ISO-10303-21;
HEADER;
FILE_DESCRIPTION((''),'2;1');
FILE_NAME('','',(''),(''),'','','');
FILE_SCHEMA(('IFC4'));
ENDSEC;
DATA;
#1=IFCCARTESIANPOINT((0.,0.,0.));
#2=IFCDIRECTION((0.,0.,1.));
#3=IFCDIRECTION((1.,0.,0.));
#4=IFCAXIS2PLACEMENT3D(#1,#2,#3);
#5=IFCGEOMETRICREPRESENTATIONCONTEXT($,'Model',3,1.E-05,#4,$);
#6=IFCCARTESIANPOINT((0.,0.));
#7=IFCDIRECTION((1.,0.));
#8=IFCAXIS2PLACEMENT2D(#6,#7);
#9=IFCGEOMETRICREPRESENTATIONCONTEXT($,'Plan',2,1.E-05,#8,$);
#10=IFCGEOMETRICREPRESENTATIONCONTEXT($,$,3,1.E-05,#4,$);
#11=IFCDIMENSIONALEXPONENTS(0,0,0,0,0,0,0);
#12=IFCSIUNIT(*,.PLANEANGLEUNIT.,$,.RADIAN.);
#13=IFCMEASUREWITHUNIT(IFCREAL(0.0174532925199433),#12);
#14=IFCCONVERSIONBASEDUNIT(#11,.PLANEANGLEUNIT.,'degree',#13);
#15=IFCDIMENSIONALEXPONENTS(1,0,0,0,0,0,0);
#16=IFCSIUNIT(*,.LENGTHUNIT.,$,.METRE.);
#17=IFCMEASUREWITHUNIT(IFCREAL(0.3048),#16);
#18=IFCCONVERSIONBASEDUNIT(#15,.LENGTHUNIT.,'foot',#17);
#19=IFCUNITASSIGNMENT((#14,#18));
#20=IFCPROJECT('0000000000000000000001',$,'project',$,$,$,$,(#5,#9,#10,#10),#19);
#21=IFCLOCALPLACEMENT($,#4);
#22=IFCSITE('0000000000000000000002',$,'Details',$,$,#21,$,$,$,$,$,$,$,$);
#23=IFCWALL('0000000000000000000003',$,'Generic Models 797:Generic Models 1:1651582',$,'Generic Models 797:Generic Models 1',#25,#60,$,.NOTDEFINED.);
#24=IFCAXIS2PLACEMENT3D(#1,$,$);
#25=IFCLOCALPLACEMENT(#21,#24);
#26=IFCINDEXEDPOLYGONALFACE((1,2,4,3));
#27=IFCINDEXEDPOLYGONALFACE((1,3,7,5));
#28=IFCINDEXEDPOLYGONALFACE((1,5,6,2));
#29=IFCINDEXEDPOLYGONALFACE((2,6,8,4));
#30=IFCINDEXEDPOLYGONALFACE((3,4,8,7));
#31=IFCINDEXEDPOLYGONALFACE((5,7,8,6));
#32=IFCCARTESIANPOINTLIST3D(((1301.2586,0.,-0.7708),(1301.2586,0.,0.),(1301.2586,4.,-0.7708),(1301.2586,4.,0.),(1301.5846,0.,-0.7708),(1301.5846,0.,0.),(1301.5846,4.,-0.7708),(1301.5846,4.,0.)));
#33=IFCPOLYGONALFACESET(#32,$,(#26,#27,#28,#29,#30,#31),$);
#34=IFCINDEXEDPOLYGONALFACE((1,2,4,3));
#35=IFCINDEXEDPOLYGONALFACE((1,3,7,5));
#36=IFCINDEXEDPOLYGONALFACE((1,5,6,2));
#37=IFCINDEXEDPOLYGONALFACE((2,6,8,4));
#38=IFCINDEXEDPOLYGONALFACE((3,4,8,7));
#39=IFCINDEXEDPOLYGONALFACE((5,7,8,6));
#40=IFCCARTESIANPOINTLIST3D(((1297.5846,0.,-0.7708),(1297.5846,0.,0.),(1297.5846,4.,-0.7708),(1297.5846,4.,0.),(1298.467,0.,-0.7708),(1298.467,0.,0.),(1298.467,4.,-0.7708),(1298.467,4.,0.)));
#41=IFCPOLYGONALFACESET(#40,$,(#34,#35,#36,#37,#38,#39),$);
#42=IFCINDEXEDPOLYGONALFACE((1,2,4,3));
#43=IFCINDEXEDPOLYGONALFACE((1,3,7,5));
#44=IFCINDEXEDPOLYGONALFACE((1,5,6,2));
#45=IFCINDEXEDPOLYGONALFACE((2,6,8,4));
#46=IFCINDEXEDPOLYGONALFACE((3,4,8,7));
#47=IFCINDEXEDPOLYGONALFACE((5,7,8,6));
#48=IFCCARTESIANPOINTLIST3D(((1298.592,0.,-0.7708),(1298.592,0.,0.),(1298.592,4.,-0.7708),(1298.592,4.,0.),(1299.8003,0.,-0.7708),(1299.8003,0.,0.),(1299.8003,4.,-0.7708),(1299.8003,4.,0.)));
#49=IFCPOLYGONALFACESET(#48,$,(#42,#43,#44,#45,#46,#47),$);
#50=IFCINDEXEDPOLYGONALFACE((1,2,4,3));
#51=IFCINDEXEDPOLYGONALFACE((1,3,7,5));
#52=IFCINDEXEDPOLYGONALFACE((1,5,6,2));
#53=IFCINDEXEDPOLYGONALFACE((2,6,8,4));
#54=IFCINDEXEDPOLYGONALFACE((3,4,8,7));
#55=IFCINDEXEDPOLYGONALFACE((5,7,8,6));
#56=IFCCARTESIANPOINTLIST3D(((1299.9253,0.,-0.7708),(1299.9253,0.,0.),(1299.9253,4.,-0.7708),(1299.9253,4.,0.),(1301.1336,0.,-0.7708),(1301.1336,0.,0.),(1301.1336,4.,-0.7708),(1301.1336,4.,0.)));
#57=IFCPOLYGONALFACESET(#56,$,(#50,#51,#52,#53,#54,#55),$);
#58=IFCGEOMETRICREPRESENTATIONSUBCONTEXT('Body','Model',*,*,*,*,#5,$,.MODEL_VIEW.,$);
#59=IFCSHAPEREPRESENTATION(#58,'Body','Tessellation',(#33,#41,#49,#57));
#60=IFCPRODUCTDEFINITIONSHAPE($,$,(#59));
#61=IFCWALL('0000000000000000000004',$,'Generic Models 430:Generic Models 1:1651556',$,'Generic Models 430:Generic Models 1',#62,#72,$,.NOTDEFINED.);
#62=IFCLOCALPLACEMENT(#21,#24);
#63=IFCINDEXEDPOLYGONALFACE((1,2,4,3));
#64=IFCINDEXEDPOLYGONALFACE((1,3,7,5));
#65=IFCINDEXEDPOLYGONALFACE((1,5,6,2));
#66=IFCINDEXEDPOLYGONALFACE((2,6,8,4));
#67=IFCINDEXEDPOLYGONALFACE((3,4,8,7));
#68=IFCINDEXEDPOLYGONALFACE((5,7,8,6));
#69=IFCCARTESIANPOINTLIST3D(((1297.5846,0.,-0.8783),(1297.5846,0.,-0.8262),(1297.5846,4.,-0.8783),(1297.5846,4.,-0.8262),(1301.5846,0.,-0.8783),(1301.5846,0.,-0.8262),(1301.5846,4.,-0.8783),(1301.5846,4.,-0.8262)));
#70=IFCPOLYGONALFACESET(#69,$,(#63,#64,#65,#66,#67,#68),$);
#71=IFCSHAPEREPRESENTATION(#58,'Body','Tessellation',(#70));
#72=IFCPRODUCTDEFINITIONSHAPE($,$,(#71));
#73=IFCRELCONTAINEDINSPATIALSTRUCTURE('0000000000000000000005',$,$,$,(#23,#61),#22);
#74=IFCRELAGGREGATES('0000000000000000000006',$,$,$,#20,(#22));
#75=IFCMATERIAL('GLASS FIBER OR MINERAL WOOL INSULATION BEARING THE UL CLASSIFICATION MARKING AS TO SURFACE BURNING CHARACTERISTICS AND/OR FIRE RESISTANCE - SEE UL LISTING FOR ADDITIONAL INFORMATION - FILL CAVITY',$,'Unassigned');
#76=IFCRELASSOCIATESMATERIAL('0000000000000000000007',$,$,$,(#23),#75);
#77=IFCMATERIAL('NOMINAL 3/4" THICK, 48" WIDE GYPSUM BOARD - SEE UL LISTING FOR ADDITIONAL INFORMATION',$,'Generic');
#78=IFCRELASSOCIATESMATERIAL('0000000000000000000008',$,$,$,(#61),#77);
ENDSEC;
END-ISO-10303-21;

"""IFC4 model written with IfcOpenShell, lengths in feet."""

from ifc_helpers import new_model, entity, si_unit, converted_unit, frame, frame_2d, origin_with_axes, origin_2d_with_axis, place, context, subcontext, project, spatial, rectangle, extrude, material, element, save


model = new_model("IFC4")

# Units and contexts
model_context = context("Model", 3, precision=1e-05, world=origin_with_axes())
plan_context = context("Plan", 2, precision=1e-05, world=origin_2d_with_axis())
context_of_model = context(None, 3, precision=1e-05, world=origin_with_axes())
body_context = subcontext(model_context, "Body", "Model", "MODEL_VIEW")
ifc_project = project(units=[converted_unit("PLANEANGLEUNIT", "degree", entity("IfcReal", 0.0174532925199433), si_unit("PLANEANGLEUNIT", "RADIAN"), dimensions=[0, 0, 0, 0, 0, 0, 0]), converted_unit("LENGTHUNIT", "foot", entity("IfcReal", 0.3048), si_unit("LENGTHUNIT", "METRE"), dimensions=[1, 0, 0, 0, 0, 0, 0])], contexts=[model_context, plan_context, context_of_model, context_of_model])

# Site
site_placement = place(None, origin_with_axes())
site = spatial("IfcSite", under=ifc_project, at=site_placement, Name="Details")

# Walls
ifc_material_1 = material(Name="GLASS FIBER OR MINERAL WOOL INSULATION BEARING THE UL CLASSIFICATION MARKING AS TO SURFACE BURNING CHARACTERISTICS AND/OR FIRE RESISTANCE - SEE UL LISTING FOR ADDITIONAL INFORMATION - FILL CAVITY", Category="Unassigned")
wall_1_placement = place(site_placement, frame((1297.5846, 0.0, -0.7708), z_axis=(0.0, 0.0, 1.0), x_axis=(0.0, 1.0, 0.0)))
element("IfcWall", 1, at=wall_1_placement, inside=site, material=ifc_material_1, Name="Generic Models 797:Generic Models 1:1651582", ObjectType="Generic Models 797:Generic Models 1", PredefinedType="NOTDEFINED", context=body_context, shape_type="SweptSolid", body=[
    extrude(rectangle(XDim=4.0, YDim=0.326, at=origin_2d_with_axis()), frame((2.0, -3.837, 0.0)), (0.0, 0.0, 1.0), 0.7708),
    extrude(rectangle(XDim=4.0, YDim=0.8824, at=origin_2d_with_axis()), frame((2.0, -0.4412, 0.0)), (0.0, 0.0, 1.0), 0.7708),
    extrude(rectangle(XDim=4.0, YDim=1.2083, at=frame_2d((0.0, 0.0), x_axis=(1.0, 0.0))), frame((2.0, -1.6115, 0.0)), (0.0, 0.0, 1.0), 0.7708),
    extrude(rectangle(XDim=4.0, YDim=1.2083, at=frame_2d((0.0, 0.0), x_axis=(1.0, 0.0))), frame((2.0, -2.9449, 0.0)), (0.0, 0.0, 1.0), 0.7708),
])
ifc_material_2 = material(Name="NOMINAL 3/4\" THICK, 48\" WIDE GYPSUM BOARD - SEE UL LISTING FOR ADDITIONAL INFORMATION", Category="Generic")
wall_2_placement = place(site_placement, frame((1297.5846, 0.0, -0.8783), z_axis=(0.0, 0.0, 1.0), x_axis=(0.0, 1.0, 0.0)))
element("IfcWall", 2, at=wall_2_placement, inside=site, material=ifc_material_2, Name="Generic Models 430:Generic Models 1:1651556", ObjectType="Generic Models 430:Generic Models 1", PredefinedType="NOTDEFINED", context=body_context, shape_type="SweptSolid", body=[
    extrude(rectangle(XDim=4.0, YDim=4.0, at=origin_2d_with_axis()), frame((2.0, -2.0, 0.0)), (0.0, 0.0, 1.0), 0.0521),
])

save(model, "model.ifc")
